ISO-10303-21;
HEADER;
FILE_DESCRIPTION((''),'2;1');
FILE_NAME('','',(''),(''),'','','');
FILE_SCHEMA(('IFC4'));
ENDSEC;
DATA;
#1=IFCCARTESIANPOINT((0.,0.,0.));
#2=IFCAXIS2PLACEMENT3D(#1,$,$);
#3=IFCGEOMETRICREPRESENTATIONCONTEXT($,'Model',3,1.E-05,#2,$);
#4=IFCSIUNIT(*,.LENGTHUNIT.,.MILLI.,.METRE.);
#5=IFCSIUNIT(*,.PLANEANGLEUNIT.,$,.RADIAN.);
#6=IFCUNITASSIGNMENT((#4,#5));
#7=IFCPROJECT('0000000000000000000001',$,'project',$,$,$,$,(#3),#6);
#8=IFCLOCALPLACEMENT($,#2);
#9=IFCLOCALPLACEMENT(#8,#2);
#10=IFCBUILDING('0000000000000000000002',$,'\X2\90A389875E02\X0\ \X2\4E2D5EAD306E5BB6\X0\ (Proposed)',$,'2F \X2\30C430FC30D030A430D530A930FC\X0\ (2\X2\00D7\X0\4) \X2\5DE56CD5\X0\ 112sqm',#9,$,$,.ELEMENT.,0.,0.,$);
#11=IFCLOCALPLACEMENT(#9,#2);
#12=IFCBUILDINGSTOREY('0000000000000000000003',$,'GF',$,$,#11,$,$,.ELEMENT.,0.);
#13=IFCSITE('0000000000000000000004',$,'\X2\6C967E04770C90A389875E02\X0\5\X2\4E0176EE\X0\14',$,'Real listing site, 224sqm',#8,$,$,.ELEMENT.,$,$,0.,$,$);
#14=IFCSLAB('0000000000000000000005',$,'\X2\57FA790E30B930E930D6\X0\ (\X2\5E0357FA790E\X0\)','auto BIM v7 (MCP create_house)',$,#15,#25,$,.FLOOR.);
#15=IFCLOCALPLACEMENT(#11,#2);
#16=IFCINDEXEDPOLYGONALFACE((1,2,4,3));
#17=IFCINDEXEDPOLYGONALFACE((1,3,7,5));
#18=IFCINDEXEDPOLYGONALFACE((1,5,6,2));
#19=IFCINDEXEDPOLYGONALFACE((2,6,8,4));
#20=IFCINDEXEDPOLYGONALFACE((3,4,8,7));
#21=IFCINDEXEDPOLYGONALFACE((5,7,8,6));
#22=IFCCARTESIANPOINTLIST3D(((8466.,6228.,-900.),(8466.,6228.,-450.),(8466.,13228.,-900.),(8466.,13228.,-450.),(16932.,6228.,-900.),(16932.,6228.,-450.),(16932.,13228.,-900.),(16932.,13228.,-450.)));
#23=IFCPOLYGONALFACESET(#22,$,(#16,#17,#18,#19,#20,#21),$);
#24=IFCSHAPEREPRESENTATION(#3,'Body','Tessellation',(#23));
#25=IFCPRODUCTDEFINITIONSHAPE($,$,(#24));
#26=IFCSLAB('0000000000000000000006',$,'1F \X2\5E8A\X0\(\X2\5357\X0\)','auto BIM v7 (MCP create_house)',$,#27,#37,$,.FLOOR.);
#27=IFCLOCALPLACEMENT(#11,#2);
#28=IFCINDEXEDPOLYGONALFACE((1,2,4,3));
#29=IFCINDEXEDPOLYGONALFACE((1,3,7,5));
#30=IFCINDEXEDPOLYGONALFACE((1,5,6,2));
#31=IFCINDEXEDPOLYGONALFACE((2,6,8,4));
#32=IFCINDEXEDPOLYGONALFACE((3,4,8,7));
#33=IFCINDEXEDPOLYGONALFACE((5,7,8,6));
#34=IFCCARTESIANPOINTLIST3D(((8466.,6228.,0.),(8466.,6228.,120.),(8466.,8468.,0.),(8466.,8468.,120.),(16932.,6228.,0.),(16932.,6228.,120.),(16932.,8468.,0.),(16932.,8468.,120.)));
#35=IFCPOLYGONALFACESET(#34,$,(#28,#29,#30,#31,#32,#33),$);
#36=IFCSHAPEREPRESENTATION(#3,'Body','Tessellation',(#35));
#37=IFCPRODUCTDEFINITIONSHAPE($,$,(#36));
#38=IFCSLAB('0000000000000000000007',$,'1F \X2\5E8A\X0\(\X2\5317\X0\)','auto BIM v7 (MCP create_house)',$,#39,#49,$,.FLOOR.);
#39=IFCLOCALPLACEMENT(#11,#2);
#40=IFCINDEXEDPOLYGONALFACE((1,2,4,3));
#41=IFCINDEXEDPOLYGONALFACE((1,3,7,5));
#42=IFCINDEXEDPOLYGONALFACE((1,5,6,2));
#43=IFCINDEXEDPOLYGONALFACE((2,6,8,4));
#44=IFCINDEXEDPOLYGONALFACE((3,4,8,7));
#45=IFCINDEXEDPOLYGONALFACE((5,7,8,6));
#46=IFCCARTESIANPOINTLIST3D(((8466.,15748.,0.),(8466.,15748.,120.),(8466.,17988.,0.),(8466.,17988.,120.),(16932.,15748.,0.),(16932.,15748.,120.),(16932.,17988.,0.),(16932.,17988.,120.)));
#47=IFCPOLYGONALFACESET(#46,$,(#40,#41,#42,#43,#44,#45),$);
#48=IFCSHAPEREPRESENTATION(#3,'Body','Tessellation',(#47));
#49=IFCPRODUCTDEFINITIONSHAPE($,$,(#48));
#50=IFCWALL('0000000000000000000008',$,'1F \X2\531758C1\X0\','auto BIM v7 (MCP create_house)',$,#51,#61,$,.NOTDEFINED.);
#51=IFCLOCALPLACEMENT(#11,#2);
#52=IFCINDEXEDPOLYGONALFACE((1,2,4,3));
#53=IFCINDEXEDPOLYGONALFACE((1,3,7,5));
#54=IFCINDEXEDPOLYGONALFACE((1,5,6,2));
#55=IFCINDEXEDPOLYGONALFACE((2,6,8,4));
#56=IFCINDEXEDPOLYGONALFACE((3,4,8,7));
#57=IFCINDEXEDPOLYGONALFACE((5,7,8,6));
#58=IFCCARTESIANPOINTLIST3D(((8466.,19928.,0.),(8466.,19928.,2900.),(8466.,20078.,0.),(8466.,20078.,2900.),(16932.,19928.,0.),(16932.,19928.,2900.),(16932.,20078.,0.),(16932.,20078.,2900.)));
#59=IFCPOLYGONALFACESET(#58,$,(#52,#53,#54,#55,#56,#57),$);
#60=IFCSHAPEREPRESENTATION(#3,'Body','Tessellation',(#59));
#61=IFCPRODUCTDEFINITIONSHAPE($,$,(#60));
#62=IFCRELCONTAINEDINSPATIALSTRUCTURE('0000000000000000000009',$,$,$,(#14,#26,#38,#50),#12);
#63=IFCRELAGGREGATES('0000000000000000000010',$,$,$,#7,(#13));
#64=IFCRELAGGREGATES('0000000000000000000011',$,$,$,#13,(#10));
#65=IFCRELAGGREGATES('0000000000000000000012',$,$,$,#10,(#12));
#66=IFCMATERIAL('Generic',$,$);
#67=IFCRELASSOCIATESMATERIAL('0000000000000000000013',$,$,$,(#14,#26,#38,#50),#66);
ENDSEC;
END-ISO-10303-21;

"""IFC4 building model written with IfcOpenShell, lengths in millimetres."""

from ifc_helpers import new_model, si_unit, frame, frame_2d, origin, place, context, project, spatial, rectangle, extrude, material, element, save


model = new_model("IFC4")

# Units and contexts
model_context = context("Model", 3, precision=1e-05, world=origin())
ifc_project = project(units=[si_unit("LENGTHUNIT", "METRE", prefix="MILLI"), si_unit("PLANEANGLEUNIT", "RADIAN")], contexts=[model_context])

# Site, building, storey
site_placement = place(None, origin())
site = spatial("IfcSite", under=ifc_project, at=site_placement, Name="沖縄県那覇市5丁目14", ObjectType="Real listing site, 224sqm", CompositionType="ELEMENT", RefElevation=0.0)
building_placement = place(site_placement, origin())
building = spatial("IfcBuilding", under=site, at=building_placement, Name="那覇市 中庭の家 (Proposed)", ObjectType="2F ツーバイフォー (2×4) 工法 112sqm", CompositionType="ELEMENT", ElevationOfRefHeight=0.0, ElevationOfTerrain=0.0)
storey_placement = place(building_placement, origin())
storey = spatial("IfcBuildingStorey", under=building, at=storey_placement, Name="GF", CompositionType="ELEMENT", Elevation=0.0)

# Slabs
ifc_material = material(Name="Generic")
slab_1_placement = place(storey_placement, frame((4233.0, 3114.0, -450.0)))
element("IfcSlab", 1, at=slab_1_placement, inside=storey, material=ifc_material, Name="基礎スラブ (布基礎)", Description="auto BIM v7 (MCP create_house)", PredefinedType="FLOOR", context=model_context, shape_type="SweptSolid", body=[
    extrude(rectangle(XDim=8466.0, YDim=7000.0, at=frame_2d((4233.0, 3500.0))), frame((4233.0, 3114.0, -450.0)), (0.0, 0.0, 1.0), 450.0),
])
slab_2_placement = place(storey_placement, frame((4233.0, 3114.0, 0.0)))
element("IfcSlab", 2, at=slab_2_placement, inside=storey, material=ifc_material, Name="1F 床(南)", Description="auto BIM v7 (MCP create_house)", PredefinedType="FLOOR", context=model_context, shape_type="SweptSolid", body=[
    extrude(rectangle(XDim=8466.0, YDim=2240.0, at=frame_2d((4233.0, 1120.0))), frame((4233.0, 3114.0, 0.0)), (0.0, 0.0, 1.0), 120.0),
])
slab_3_placement = place(storey_placement, frame((4233.0, 7874.0, 0.0)))
element("IfcSlab", 3, at=slab_3_placement, inside=storey, material=ifc_material, Name="1F 床(北)", Description="auto BIM v7 (MCP create_house)", PredefinedType="FLOOR", context=model_context, shape_type="SweptSolid", body=[
    extrude(rectangle(XDim=8466.0, YDim=2240.0, at=frame_2d((4233.0, 1120.0))), frame((4233.0, 7874.0, 0.0)), (0.0, 0.0, 1.0), 120.0),
])

# Wall
wall_1_placement = place(storey_placement, frame((4233.0, 9964.0, 0.0)))
element("IfcWall", 4, at=wall_1_placement, inside=storey, material=ifc_material, Name="1F 北壁", Description="auto BIM v7 (MCP create_house)", PredefinedType="NOTDEFINED", context=model_context, shape_type="SweptSolid", body=[
    extrude(rectangle(XDim=8466.0, YDim=150.0, at=frame_2d((4233.0, 75.0))), frame((4233.0, 9964.0, 0.0)), (0.0, 0.0, 1.0), 2900.0),
])

save(model, "model.ifc")
